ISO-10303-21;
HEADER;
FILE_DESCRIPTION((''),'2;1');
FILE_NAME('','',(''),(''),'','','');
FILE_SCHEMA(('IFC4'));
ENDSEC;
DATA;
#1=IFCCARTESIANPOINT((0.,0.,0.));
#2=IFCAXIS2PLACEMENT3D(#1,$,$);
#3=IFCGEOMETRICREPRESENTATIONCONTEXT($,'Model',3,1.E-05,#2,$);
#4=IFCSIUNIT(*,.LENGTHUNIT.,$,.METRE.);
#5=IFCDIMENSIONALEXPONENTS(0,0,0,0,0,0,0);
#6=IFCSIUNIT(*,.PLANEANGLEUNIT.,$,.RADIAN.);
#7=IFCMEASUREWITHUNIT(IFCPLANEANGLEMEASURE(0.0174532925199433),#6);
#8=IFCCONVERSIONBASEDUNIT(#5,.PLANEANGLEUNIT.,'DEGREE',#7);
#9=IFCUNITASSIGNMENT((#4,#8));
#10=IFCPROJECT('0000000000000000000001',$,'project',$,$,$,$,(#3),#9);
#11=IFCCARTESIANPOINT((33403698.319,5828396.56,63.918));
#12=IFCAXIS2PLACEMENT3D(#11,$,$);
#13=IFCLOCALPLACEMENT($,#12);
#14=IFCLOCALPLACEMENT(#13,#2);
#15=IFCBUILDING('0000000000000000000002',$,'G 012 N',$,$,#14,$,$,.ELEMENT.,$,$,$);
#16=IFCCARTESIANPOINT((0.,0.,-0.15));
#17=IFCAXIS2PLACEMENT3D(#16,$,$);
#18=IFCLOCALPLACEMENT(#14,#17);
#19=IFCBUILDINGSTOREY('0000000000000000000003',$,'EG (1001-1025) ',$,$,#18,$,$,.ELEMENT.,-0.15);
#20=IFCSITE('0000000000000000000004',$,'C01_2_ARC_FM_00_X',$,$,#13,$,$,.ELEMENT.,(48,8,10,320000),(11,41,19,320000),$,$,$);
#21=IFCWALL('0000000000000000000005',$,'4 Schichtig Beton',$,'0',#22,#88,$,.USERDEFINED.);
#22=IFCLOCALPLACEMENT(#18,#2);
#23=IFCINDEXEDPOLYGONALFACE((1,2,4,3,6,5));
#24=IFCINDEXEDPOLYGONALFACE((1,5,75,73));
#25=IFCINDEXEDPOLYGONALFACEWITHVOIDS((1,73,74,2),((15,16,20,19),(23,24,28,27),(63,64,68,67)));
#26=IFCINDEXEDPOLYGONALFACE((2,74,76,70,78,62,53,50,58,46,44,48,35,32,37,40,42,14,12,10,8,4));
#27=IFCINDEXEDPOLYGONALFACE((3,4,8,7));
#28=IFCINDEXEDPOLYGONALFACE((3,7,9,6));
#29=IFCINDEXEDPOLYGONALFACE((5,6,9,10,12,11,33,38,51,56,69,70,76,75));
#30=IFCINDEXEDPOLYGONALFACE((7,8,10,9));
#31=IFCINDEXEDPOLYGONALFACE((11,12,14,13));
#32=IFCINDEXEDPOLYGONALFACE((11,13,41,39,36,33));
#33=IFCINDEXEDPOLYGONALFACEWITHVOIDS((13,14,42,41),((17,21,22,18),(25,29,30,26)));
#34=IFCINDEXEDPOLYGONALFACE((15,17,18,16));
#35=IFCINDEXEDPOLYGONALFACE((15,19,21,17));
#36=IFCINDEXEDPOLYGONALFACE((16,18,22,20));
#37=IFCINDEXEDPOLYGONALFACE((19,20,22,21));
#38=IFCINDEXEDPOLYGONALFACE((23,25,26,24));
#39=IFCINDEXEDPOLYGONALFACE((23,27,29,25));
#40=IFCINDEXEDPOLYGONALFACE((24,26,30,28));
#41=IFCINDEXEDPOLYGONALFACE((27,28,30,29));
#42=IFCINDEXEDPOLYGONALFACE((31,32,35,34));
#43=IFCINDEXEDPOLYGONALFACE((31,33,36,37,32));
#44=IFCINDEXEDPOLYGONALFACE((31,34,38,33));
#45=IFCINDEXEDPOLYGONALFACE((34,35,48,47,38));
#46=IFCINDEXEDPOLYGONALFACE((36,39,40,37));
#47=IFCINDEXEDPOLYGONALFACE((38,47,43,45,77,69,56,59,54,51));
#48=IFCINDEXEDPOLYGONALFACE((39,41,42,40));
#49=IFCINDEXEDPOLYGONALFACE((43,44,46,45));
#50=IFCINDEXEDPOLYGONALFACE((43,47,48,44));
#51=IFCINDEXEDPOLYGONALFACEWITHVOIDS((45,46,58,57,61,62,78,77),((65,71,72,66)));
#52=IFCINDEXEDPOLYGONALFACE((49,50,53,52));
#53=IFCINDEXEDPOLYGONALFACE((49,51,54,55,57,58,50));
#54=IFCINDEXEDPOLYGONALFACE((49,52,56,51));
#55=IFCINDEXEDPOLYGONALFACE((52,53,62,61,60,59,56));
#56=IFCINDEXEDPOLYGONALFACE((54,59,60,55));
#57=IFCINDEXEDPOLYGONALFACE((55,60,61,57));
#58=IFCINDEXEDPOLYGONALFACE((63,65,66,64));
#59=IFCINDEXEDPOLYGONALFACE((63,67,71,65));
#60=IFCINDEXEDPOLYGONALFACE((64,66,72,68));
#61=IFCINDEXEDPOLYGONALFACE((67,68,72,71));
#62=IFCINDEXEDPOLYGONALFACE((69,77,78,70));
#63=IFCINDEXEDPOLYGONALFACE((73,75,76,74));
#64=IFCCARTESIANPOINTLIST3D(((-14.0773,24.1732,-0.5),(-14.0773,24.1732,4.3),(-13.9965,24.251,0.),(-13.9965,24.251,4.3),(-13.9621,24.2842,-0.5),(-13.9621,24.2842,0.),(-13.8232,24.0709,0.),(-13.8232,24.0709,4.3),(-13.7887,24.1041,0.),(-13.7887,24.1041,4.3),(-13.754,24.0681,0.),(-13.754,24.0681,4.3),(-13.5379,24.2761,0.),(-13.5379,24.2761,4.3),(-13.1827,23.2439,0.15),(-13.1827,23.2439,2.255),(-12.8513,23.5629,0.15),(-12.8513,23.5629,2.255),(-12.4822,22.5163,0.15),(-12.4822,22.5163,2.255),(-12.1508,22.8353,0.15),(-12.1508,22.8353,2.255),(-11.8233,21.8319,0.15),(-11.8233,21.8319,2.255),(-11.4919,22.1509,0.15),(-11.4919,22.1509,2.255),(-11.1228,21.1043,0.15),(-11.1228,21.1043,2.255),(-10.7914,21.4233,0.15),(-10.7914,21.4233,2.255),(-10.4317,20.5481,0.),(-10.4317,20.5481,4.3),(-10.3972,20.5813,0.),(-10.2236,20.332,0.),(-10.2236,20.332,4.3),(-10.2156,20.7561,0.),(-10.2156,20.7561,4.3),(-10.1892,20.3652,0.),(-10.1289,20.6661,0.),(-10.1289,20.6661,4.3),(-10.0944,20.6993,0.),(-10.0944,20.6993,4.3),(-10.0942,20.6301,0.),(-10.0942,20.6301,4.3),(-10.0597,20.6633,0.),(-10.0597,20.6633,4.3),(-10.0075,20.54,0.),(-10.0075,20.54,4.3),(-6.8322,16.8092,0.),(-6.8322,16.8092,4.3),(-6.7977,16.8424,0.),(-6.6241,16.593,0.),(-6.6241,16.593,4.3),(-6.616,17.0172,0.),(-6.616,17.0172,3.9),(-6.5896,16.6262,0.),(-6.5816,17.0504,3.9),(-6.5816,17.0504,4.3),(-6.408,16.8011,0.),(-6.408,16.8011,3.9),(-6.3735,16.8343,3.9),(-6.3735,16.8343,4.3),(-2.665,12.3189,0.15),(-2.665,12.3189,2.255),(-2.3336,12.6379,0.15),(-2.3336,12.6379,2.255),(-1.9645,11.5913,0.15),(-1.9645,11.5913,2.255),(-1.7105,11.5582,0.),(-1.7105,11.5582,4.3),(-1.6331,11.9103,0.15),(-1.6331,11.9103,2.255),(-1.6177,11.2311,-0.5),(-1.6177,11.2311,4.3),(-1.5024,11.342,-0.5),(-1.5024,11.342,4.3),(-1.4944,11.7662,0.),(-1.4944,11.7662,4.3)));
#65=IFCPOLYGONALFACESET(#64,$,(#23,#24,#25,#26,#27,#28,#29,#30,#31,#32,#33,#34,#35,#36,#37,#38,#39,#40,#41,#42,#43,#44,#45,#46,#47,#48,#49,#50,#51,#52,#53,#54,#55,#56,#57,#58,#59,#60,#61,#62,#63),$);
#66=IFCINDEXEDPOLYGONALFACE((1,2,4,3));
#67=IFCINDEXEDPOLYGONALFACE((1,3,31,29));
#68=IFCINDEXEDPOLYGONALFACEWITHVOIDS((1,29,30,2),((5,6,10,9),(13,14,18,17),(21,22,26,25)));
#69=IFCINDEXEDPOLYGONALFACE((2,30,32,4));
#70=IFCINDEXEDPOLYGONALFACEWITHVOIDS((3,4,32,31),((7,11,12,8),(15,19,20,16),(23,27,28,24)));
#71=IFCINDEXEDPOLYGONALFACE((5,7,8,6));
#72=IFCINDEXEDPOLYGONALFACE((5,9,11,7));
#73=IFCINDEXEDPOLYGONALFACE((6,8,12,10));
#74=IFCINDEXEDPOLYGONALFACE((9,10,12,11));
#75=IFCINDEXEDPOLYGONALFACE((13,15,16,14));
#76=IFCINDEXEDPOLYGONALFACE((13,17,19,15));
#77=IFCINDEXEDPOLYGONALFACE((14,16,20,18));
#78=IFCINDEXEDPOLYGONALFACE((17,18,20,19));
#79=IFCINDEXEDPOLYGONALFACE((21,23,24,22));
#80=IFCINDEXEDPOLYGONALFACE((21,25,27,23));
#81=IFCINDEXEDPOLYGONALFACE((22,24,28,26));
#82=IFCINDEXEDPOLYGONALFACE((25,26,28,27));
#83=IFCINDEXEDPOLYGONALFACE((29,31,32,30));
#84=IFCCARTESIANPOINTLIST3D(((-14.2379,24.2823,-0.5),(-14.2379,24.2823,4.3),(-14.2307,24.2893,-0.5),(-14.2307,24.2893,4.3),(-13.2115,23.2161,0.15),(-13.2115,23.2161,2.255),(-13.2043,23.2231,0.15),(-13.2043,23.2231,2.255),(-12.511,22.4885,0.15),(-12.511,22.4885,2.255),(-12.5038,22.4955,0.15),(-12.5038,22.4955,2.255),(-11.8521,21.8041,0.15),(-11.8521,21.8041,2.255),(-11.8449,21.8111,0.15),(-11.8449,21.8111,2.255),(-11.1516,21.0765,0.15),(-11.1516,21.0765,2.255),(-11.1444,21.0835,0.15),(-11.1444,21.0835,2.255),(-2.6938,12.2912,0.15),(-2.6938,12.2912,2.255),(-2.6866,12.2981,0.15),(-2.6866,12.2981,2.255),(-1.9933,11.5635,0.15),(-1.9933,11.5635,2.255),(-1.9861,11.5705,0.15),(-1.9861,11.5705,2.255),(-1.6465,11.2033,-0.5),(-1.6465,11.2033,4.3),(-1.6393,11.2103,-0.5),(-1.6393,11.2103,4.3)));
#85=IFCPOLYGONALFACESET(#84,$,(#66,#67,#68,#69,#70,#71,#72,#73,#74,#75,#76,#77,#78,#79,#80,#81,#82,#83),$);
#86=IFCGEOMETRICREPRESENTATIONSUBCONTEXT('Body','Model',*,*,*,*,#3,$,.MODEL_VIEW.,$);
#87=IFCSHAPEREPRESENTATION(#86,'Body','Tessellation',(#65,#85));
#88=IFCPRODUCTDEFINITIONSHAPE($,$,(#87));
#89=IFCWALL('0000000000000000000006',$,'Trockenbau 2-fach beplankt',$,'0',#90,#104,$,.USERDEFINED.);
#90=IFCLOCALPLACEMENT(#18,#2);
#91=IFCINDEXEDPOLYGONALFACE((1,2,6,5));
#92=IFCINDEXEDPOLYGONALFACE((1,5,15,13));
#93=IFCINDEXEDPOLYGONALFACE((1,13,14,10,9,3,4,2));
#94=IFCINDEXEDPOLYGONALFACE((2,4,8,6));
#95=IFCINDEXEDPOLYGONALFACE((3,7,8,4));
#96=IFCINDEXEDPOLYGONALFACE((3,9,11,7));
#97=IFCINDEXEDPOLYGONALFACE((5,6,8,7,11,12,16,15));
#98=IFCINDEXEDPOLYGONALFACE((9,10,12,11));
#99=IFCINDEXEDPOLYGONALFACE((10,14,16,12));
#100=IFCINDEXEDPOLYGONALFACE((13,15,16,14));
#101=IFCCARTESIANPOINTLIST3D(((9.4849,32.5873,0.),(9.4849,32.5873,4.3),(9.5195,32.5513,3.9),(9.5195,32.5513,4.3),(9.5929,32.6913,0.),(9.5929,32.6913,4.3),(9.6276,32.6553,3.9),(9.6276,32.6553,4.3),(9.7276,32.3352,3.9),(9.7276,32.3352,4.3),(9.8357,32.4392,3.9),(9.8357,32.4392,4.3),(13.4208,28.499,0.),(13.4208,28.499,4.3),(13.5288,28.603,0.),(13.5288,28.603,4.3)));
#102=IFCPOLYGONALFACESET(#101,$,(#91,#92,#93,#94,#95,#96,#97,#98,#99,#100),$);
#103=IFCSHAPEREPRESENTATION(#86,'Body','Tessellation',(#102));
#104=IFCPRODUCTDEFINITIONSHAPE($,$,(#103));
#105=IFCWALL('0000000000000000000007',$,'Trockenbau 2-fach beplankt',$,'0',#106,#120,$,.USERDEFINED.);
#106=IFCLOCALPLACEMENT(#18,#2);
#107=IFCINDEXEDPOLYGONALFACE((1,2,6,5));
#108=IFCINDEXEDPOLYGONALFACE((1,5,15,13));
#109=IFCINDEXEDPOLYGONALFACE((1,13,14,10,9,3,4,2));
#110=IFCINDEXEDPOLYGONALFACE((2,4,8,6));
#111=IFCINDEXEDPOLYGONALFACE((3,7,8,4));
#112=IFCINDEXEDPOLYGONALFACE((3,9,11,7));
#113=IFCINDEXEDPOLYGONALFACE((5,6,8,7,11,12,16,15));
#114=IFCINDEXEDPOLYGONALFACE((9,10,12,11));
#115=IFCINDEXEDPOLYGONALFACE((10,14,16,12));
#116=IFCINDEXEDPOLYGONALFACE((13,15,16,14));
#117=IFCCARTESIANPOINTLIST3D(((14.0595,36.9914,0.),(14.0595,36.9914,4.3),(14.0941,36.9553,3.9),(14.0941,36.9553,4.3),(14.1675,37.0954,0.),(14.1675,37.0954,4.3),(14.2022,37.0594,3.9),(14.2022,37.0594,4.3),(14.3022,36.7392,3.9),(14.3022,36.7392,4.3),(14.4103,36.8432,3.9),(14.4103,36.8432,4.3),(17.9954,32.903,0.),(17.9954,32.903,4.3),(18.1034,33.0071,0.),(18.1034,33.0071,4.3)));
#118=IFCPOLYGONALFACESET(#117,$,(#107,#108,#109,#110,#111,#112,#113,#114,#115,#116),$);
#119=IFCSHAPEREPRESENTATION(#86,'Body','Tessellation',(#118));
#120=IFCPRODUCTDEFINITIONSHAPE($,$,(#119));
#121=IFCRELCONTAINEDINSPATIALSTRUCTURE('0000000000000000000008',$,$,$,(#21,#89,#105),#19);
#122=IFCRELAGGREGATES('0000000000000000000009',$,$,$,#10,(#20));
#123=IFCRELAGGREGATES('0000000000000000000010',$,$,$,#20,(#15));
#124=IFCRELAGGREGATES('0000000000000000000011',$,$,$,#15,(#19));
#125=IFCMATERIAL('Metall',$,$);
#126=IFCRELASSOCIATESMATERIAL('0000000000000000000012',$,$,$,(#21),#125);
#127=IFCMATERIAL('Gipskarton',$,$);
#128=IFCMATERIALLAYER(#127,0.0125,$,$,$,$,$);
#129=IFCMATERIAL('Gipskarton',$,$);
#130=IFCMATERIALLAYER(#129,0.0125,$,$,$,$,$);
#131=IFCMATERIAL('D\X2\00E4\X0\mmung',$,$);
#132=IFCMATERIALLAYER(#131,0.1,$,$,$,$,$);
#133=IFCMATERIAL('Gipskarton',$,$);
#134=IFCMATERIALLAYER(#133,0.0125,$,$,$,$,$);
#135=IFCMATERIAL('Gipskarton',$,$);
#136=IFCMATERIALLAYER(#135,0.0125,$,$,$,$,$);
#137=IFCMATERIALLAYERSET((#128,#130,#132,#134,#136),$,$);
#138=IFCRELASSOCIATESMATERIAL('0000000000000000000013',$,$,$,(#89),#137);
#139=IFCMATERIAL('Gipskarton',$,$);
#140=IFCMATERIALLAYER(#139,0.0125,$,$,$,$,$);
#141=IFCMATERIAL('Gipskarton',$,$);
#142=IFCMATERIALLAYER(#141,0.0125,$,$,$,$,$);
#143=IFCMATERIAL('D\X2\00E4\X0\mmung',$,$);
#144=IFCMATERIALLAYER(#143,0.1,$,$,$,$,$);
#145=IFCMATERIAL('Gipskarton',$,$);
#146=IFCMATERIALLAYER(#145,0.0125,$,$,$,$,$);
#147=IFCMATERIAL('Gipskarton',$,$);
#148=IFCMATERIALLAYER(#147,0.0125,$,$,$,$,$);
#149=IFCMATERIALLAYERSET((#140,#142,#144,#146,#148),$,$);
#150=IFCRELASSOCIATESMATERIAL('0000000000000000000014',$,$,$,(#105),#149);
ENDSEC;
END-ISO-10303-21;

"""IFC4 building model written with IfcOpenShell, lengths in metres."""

from ifc_helpers import new_model, entity, si_unit, converted_unit, frame, frame_2d, origin, origin_with_axes, place, context, subcontext, project, spatial, polyline, rectangle, outline, extrude, clip, bounded_halfspace, material, layer, layer_set, layer_usage, element, save


model = new_model("IFC4")

# Units and contexts
model_context = context("Model", 3, precision=1e-05, world=origin())
body_context = subcontext(model_context, "Body", "Model", "MODEL_VIEW")
ifc_project = project(units=[si_unit("LENGTHUNIT", "METRE"), converted_unit("PLANEANGLEUNIT", "DEGREE", entity("IfcPlaneAngleMeasure", 0.0174532925199433), si_unit("PLANEANGLEUNIT", "RADIAN"), dimensions=[0, 0, 0, 0, 0, 0, 0])], contexts=[model_context])

# Site, building, storey
site_placement = place(None, frame((33403698.319, 5828396.56, 63.918)))
site = spatial("IfcSite", under=ifc_project, at=site_placement, Name="C01_2_ARC_FM_00_X", CompositionType="ELEMENT", RefLatitude=(48, 8, 10, 320000), RefLongitude=(11, 41, 19, 320000))
building_placement = place(site_placement, origin())
building = spatial("IfcBuilding", under=site, at=building_placement, Name="G 012 N", CompositionType="ELEMENT")
storey_placement = place(building_placement, frame((0.0, 0.0, -0.15)))
storey = spatial("IfcBuildingStorey", under=building, at=storey_placement, Name="EG (1001-1025) ", CompositionType="ELEMENT", Elevation=-0.15)

# Wall, openings
ifc_material_1 = material(Name="Metall")
wall_1_placement = place(storey_placement, frame((-14.2379, 24.2823, -0.5), z_axis=(0.0, 0.0, 1.0), x_axis=(0.693551, -0.720408, 0.0)))
wall_1 = element("IfcWall", 1, at=wall_1_placement, inside=storey, material=ifc_material_1, Name="4 Schichtig Beton", ObjectType="0", PredefinedType="USERDEFINED", context=body_context, shape_type="Clipping", body=[
    clip(clip(clip(clip(clip(clip(extrude(outline(polyline([(-9.3236, 8.976), (8.6414, 8.976), (8.6414, 9.136), (8.3414, 9.136), (8.3414, 9.436), (-4.0086, 9.436), (-4.0086, 9.3882), (-3.8836, 9.3882), (-3.8836, 9.136), (-4.1836, 9.136), (-4.1836, 9.3882), (-4.0586, 9.3882), (-4.0586, 9.436), (-9.0236, 9.436), (-9.0236, 9.136), (-9.3236, 9.136), (-9.3236, 8.976)]), holes=[polyline([(1.3064, 9.136), (1.0064, 9.136), (1.0064, 9.3882), (1.3064, 9.3882), (1.3064, 9.136)])]), frame((9.5136, -8.936, 0.0), z_axis=(0.0, 0.0, 1.0), x_axis=(1.0, 0.0, 0.0)), (0.0, 0.0, 1.0), 4.8), bounded_halfspace(frame((10.066, 0.3609, 0.5), z_axis=(0.0, 0.0, 1.0), x_axis=(1.0, 0.0, 0.0)), True, origin_with_axes(), polyline([(10.82, 0.2), (17.855, 0.2), (17.855, 0.5), (5.505, 0.5), (5.505, 0.4521), (5.63, 0.4521), (5.63, 0.2), (10.52, 0.2), (10.52, 0.4521), (10.82, 0.4521), (10.82, 0.2)]))), bounded_halfspace(frame((3.7583, 0.384, 0.5), z_axis=(0.0, 0.0, 1.0), x_axis=(-1.0, 0.0, 0.0)), True, origin_with_axes(), polyline([(5.455, 0.5), (0.49, 0.5), (0.49, 0.2), (5.33, 0.2), (5.33, 0.4521), (5.455, 0.4521), (5.455, 0.5)]))), bounded_halfspace(frame((0.315, 0.1761, 0.5), z_axis=(0.0, 0.0, -1.0), x_axis=(1.0, 0.0, 0.0)), True, origin_with_axes(), polyline([(0.19, 0.1521), (0.44, 0.1521), (0.44, 0.2), (0.19, 0.2), (0.19, 0.1521)]))), bounded_halfspace(frame((10.67, 0.1761, 0.5), z_axis=(0.0, 0.0, -1.0), x_axis=(1.0, 0.0, 0.0)), True, origin_with_axes(), polyline([(10.52, 0.1521), (10.82, 0.1521), (10.82, 0.2), (10.52, 0.2), (10.52, 0.1521)]))), bounded_halfspace(frame((5.48, 0.1761, 0.5), z_axis=(0.0, 0.0, -1.0), x_axis=(1.0, 0.0, 0.0)), True, origin_with_axes(), polyline([(5.33, 0.1521), (5.63, 0.1521), (5.63, 0.2), (5.33, 0.2), (5.33, 0.1521)]))), bounded_halfspace(frame((10.67, 0.4761, 4.4), z_axis=(0.0, 0.0, -1.0), x_axis=(1.0, 0.0, 0.0)), True, origin_with_axes(), polyline([(10.52, 0.4521), (10.82, 0.4521), (10.82, 0.5), (10.52, 0.5), (10.52, 0.4521)]))),
    clip(clip(clip(clip(clip(clip(extrude(rectangle(XDim=18.155, YDim=0.01, at=frame_2d((-9.0775, -0.005), x_axis=(-1.0, 0.0))), frame((18.155, 0.01, 0.0), z_axis=(0.0, 0.0, 1.0), x_axis=(1.0, 0.0, 0.0)), (0.0, 0.0, 1.0), 4.8), bounded_halfspace(frame((10.066, 0.3609, 0.5), z_axis=(0.0, 0.0, 1.0), x_axis=(1.0, 0.0, 0.0)), True, origin_with_axes(), polyline([(10.82, 0.2), (17.855, 0.2), (17.855, 0.5), (5.505, 0.5), (5.505, 0.4521), (5.63, 0.4521), (5.63, 0.2), (10.52, 0.2), (10.52, 0.4521), (10.82, 0.4521), (10.82, 0.2)]))), bounded_halfspace(frame((3.7583, 0.384, 0.5), z_axis=(0.0, 0.0, 1.0), x_axis=(-1.0, 0.0, 0.0)), True, origin_with_axes(), polyline([(5.455, 0.5), (0.49, 0.5), (0.49, 0.2), (5.33, 0.2), (5.33, 0.4521), (5.455, 0.4521), (5.455, 0.5)]))), bounded_halfspace(frame((0.315, 0.1761, 0.5), z_axis=(0.0, 0.0, -1.0), x_axis=(1.0, 0.0, 0.0)), True, origin_with_axes(), polyline([(0.19, 0.1521), (0.44, 0.1521), (0.44, 0.2), (0.19, 0.2), (0.19, 0.1521)]))), bounded_halfspace(frame((10.67, 0.1761, 0.5), z_axis=(0.0, 0.0, -1.0), x_axis=(1.0, 0.0, 0.0)), True, origin_with_axes(), polyline([(10.52, 0.1521), (10.82, 0.1521), (10.82, 0.2), (10.52, 0.2), (10.52, 0.1521)]))), bounded_halfspace(frame((5.48, 0.1761, 0.5), z_axis=(0.0, 0.0, -1.0), x_axis=(1.0, 0.0, 0.0)), True, origin_with_axes(), polyline([(5.33, 0.1521), (5.63, 0.1521), (5.63, 0.2), (5.33, 0.2), (5.33, 0.1521)]))), bounded_halfspace(frame((10.67, 0.4761, 4.4), z_axis=(0.0, 0.0, -1.0), x_axis=(1.0, 0.0, 0.0)), True, origin_with_axes(), polyline([(10.52, 0.4521), (10.82, 0.4521), (10.82, 0.5), (10.52, 0.5), (10.52, 0.4521)]))),
])
opening_1_placement = place(wall_1_placement, frame((1.48, 0.0, 0.65), z_axis=(0.0, 1.0, 0.0), x_axis=(0.0, 0.0, 1.0)))
element("IfcOpeningElement", 2, at=opening_1_placement, cuts=wall_1, ObjectType="0", PredefinedType="USERDEFINED", context=body_context, shape_type="SweptSolid", body=[
    extrude(outline(polyline([(0.0, 1.01), (2.105, 1.01), (2.105, 0.0), (0.0, 0.0), (0.0, 1.01)])), origin_with_axes(), (0.0, 0.0, 1.0), 0.01),
    extrude(outline(polyline([(0.0, 1.01), (2.105, 1.01), (2.105, 0.0), (0.0, 0.0), (0.0, 1.01)])), frame((0.0, 0.0, 0.01), z_axis=(0.0, 0.0, 1.0), x_axis=(1.0, 0.0, 0.0)), (0.0, 0.0, 1.0), 0.03),
    extrude(outline(polyline([(0.0, 1.01), (2.105, 1.01), (2.105, 0.0), (0.0, 0.0), (0.0, 1.01)])), frame((0.0, 0.0, 0.04), z_axis=(0.0, 0.0, 1.0), x_axis=(1.0, 0.0, 0.0)), (0.0, 0.0, 1.0), 0.16),
    extrude(outline(polyline([(0.0, 1.01), (2.105, 1.01), (2.105, 0.0), (0.0, 0.0), (0.0, 1.01)])), frame((0.0, 0.0, 0.2), z_axis=(0.0, 0.0, 1.0), x_axis=(1.0, 0.0, 0.0)), (0.0, 0.0, 1.0), 0.3),
])
opening_2_placement = place(wall_1_placement, frame((3.44, 0.0, 0.65), z_axis=(0.0, 1.0, 0.0), x_axis=(0.0, 0.0, 1.0)))
element("IfcOpeningElement", 3, at=opening_2_placement, cuts=wall_1, ObjectType="0", PredefinedType="USERDEFINED", context=body_context, shape_type="SweptSolid", body=[
    extrude(outline(polyline([(0.0, 1.01), (2.105, 1.01), (2.105, 0.0), (0.0, 0.0), (0.0, 1.01)])), origin_with_axes(), (0.0, 0.0, 1.0), 0.01),
    extrude(outline(polyline([(0.0, 1.01), (2.105, 1.01), (2.105, 0.0), (0.0, 0.0), (0.0, 1.01)])), frame((0.0, 0.0, 0.01), z_axis=(0.0, 0.0, 1.0), x_axis=(1.0, 0.0, 0.0)), (0.0, 0.0, 1.0), 0.03),
    extrude(outline(polyline([(0.0, 1.01), (2.105, 1.01), (2.105, 0.0), (0.0, 0.0), (0.0, 1.01)])), frame((0.0, 0.0, 0.04), z_axis=(0.0, 0.0, 1.0), x_axis=(1.0, 0.0, 0.0)), (0.0, 0.0, 1.0), 0.16),
    extrude(outline(polyline([(0.0, 1.01), (2.105, 1.01), (2.105, 0.0), (0.0, 0.0), (0.0, 1.01)])), frame((0.0, 0.0, 0.2), z_axis=(0.0, 0.0, 1.0), x_axis=(1.0, 0.0, 0.0)), (0.0, 0.0, 1.0), 0.3),
])
opening_3_placement = place(wall_1_placement, frame((16.645, 0.0, 0.65), z_axis=(0.0, 1.0, 0.0), x_axis=(0.0, 0.0, 1.0)))
element("IfcOpeningElement", 4, at=opening_3_placement, cuts=wall_1, ObjectType="0", PredefinedType="USERDEFINED", context=body_context, shape_type="SweptSolid", body=[
    extrude(outline(polyline([(0.0, 1.01), (2.105, 1.01), (2.105, 0.0), (0.0, 0.0), (0.0, 1.01)])), origin_with_axes(), (0.0, 0.0, 1.0), 0.01),
    extrude(outline(polyline([(0.0, 1.01), (2.105, 1.01), (2.105, 0.0), (0.0, 0.0), (0.0, 1.01)])), frame((0.0, 0.0, 0.01), z_axis=(0.0, 0.0, 1.0), x_axis=(1.0, 0.0, 0.0)), (0.0, 0.0, 1.0), 0.03),
    extrude(outline(polyline([(0.0, 1.01), (2.105, 1.01), (2.105, 0.0), (0.0, 0.0), (0.0, 1.01)])), frame((0.0, 0.0, 0.04), z_axis=(0.0, 0.0, 1.0), x_axis=(1.0, 0.0, 0.0)), (0.0, 0.0, 1.0), 0.16),
    extrude(outline(polyline([(0.0, 1.01), (2.105, 1.01), (2.105, 0.0), (0.0, 0.0), (0.0, 1.01)])), frame((0.0, 0.0, 0.2), z_axis=(0.0, 0.0, 1.0), x_axis=(1.0, 0.0, 0.0)), (0.0, 0.0, 1.0), 0.3),
])

# Walls
ifc_material_2 = material(Name="Gipskarton")
ifc_layer_1 = layer(ifc_material_2, 0.0125)
ifc_material_3 = material(Name="Gipskarton")
ifc_layer_2 = layer(ifc_material_3, 0.0125)
ifc_material_4 = material(Name="Dämmung")
ifc_layer_3 = layer(ifc_material_4, 0.1)
ifc_material_5 = material(Name="Gipskarton")
ifc_layer_4 = layer(ifc_material_5, 0.0125)
ifc_material_6 = material(Name="Gipskarton")
ifc_layer_5 = layer(ifc_material_6, 0.0125)
ifc_layer_set_1 = layer_set([ifc_layer_1, ifc_layer_2, ifc_layer_3, ifc_layer_4, ifc_layer_5])
ifc_layer_usage_1 = layer_usage(ifc_layer_set_1, "AXIS2", "POSITIVE", 0.0)
wall_2_placement = place(storey_placement, frame((9.4849, 32.5873, 0.0), z_axis=(0.0, 0.0, 1.0), x_axis=(0.693551, -0.720408, 0.0)))
element("IfcWall", 5, at=wall_2_placement, inside=storey, material=ifc_layer_usage_1, Name="Trockenbau 2-fach beplankt", ObjectType="0", PredefinedType="USERDEFINED", context=body_context, shape_type="Clipping", body=[
    clip(extrude(rectangle(XDim=5.675, YDim=0.15, at=frame_2d((2.8375, 0.075), x_axis=(1.0, 0.0))), origin_with_axes(), (0.0, 0.0, 1.0), 4.3), bounded_halfspace(frame((0.2, 0.075, 3.9), z_axis=(0.0, 0.0, -1.0), x_axis=(0.0, -1.0, 0.0)), True, origin_with_axes(), polyline([(0.05, 0.15), (0.05, 0.0), (0.35, 0.0), (0.35, 0.15), (0.05, 0.15)]))),
])
ifc_material_7 = material(Name="Gipskarton")
ifc_layer_6 = layer(ifc_material_7, 0.0125)
ifc_material_8 = material(Name="Gipskarton")
ifc_layer_7 = layer(ifc_material_8, 0.0125)
ifc_material_9 = material(Name="Dämmung")
ifc_layer_8 = layer(ifc_material_9, 0.1)
ifc_material_10 = material(Name="Gipskarton")
ifc_layer_9 = layer(ifc_material_10, 0.0125)
ifc_material_11 = material(Name="Gipskarton")
ifc_layer_10 = layer(ifc_material_11, 0.0125)
ifc_layer_set_2 = layer_set([ifc_layer_6, ifc_layer_7, ifc_layer_8, ifc_layer_9, ifc_layer_10])
ifc_layer_usage_2 = layer_usage(ifc_layer_set_2, "AXIS2", "POSITIVE", 0.0)
wall_3_placement = place(storey_placement, frame((14.0595, 36.9914, 0.0), z_axis=(0.0, 0.0, 1.0), x_axis=(0.693551, -0.720408, 0.0)))
element("IfcWall", 6, at=wall_3_placement, inside=storey, material=ifc_layer_usage_2, Name="Trockenbau 2-fach beplankt", ObjectType="0", PredefinedType="USERDEFINED", context=body_context, shape_type="Clipping", body=[
    clip(extrude(rectangle(XDim=5.675, YDim=0.15, at=frame_2d((2.8375, 0.075), x_axis=(1.0, 0.0))), origin_with_axes(), (0.0, 0.0, 1.0), 4.3), bounded_halfspace(frame((0.2, 0.075, 3.9), z_axis=(0.0, 0.0, -1.0), x_axis=(0.0, -1.0, 0.0)), True, origin_with_axes(), polyline([(0.05, 0.15), (0.05, 0.0), (0.35, 0.0), (0.35, 0.15), (0.05, 0.15)]))),
])

save(model, "model.ifc")
